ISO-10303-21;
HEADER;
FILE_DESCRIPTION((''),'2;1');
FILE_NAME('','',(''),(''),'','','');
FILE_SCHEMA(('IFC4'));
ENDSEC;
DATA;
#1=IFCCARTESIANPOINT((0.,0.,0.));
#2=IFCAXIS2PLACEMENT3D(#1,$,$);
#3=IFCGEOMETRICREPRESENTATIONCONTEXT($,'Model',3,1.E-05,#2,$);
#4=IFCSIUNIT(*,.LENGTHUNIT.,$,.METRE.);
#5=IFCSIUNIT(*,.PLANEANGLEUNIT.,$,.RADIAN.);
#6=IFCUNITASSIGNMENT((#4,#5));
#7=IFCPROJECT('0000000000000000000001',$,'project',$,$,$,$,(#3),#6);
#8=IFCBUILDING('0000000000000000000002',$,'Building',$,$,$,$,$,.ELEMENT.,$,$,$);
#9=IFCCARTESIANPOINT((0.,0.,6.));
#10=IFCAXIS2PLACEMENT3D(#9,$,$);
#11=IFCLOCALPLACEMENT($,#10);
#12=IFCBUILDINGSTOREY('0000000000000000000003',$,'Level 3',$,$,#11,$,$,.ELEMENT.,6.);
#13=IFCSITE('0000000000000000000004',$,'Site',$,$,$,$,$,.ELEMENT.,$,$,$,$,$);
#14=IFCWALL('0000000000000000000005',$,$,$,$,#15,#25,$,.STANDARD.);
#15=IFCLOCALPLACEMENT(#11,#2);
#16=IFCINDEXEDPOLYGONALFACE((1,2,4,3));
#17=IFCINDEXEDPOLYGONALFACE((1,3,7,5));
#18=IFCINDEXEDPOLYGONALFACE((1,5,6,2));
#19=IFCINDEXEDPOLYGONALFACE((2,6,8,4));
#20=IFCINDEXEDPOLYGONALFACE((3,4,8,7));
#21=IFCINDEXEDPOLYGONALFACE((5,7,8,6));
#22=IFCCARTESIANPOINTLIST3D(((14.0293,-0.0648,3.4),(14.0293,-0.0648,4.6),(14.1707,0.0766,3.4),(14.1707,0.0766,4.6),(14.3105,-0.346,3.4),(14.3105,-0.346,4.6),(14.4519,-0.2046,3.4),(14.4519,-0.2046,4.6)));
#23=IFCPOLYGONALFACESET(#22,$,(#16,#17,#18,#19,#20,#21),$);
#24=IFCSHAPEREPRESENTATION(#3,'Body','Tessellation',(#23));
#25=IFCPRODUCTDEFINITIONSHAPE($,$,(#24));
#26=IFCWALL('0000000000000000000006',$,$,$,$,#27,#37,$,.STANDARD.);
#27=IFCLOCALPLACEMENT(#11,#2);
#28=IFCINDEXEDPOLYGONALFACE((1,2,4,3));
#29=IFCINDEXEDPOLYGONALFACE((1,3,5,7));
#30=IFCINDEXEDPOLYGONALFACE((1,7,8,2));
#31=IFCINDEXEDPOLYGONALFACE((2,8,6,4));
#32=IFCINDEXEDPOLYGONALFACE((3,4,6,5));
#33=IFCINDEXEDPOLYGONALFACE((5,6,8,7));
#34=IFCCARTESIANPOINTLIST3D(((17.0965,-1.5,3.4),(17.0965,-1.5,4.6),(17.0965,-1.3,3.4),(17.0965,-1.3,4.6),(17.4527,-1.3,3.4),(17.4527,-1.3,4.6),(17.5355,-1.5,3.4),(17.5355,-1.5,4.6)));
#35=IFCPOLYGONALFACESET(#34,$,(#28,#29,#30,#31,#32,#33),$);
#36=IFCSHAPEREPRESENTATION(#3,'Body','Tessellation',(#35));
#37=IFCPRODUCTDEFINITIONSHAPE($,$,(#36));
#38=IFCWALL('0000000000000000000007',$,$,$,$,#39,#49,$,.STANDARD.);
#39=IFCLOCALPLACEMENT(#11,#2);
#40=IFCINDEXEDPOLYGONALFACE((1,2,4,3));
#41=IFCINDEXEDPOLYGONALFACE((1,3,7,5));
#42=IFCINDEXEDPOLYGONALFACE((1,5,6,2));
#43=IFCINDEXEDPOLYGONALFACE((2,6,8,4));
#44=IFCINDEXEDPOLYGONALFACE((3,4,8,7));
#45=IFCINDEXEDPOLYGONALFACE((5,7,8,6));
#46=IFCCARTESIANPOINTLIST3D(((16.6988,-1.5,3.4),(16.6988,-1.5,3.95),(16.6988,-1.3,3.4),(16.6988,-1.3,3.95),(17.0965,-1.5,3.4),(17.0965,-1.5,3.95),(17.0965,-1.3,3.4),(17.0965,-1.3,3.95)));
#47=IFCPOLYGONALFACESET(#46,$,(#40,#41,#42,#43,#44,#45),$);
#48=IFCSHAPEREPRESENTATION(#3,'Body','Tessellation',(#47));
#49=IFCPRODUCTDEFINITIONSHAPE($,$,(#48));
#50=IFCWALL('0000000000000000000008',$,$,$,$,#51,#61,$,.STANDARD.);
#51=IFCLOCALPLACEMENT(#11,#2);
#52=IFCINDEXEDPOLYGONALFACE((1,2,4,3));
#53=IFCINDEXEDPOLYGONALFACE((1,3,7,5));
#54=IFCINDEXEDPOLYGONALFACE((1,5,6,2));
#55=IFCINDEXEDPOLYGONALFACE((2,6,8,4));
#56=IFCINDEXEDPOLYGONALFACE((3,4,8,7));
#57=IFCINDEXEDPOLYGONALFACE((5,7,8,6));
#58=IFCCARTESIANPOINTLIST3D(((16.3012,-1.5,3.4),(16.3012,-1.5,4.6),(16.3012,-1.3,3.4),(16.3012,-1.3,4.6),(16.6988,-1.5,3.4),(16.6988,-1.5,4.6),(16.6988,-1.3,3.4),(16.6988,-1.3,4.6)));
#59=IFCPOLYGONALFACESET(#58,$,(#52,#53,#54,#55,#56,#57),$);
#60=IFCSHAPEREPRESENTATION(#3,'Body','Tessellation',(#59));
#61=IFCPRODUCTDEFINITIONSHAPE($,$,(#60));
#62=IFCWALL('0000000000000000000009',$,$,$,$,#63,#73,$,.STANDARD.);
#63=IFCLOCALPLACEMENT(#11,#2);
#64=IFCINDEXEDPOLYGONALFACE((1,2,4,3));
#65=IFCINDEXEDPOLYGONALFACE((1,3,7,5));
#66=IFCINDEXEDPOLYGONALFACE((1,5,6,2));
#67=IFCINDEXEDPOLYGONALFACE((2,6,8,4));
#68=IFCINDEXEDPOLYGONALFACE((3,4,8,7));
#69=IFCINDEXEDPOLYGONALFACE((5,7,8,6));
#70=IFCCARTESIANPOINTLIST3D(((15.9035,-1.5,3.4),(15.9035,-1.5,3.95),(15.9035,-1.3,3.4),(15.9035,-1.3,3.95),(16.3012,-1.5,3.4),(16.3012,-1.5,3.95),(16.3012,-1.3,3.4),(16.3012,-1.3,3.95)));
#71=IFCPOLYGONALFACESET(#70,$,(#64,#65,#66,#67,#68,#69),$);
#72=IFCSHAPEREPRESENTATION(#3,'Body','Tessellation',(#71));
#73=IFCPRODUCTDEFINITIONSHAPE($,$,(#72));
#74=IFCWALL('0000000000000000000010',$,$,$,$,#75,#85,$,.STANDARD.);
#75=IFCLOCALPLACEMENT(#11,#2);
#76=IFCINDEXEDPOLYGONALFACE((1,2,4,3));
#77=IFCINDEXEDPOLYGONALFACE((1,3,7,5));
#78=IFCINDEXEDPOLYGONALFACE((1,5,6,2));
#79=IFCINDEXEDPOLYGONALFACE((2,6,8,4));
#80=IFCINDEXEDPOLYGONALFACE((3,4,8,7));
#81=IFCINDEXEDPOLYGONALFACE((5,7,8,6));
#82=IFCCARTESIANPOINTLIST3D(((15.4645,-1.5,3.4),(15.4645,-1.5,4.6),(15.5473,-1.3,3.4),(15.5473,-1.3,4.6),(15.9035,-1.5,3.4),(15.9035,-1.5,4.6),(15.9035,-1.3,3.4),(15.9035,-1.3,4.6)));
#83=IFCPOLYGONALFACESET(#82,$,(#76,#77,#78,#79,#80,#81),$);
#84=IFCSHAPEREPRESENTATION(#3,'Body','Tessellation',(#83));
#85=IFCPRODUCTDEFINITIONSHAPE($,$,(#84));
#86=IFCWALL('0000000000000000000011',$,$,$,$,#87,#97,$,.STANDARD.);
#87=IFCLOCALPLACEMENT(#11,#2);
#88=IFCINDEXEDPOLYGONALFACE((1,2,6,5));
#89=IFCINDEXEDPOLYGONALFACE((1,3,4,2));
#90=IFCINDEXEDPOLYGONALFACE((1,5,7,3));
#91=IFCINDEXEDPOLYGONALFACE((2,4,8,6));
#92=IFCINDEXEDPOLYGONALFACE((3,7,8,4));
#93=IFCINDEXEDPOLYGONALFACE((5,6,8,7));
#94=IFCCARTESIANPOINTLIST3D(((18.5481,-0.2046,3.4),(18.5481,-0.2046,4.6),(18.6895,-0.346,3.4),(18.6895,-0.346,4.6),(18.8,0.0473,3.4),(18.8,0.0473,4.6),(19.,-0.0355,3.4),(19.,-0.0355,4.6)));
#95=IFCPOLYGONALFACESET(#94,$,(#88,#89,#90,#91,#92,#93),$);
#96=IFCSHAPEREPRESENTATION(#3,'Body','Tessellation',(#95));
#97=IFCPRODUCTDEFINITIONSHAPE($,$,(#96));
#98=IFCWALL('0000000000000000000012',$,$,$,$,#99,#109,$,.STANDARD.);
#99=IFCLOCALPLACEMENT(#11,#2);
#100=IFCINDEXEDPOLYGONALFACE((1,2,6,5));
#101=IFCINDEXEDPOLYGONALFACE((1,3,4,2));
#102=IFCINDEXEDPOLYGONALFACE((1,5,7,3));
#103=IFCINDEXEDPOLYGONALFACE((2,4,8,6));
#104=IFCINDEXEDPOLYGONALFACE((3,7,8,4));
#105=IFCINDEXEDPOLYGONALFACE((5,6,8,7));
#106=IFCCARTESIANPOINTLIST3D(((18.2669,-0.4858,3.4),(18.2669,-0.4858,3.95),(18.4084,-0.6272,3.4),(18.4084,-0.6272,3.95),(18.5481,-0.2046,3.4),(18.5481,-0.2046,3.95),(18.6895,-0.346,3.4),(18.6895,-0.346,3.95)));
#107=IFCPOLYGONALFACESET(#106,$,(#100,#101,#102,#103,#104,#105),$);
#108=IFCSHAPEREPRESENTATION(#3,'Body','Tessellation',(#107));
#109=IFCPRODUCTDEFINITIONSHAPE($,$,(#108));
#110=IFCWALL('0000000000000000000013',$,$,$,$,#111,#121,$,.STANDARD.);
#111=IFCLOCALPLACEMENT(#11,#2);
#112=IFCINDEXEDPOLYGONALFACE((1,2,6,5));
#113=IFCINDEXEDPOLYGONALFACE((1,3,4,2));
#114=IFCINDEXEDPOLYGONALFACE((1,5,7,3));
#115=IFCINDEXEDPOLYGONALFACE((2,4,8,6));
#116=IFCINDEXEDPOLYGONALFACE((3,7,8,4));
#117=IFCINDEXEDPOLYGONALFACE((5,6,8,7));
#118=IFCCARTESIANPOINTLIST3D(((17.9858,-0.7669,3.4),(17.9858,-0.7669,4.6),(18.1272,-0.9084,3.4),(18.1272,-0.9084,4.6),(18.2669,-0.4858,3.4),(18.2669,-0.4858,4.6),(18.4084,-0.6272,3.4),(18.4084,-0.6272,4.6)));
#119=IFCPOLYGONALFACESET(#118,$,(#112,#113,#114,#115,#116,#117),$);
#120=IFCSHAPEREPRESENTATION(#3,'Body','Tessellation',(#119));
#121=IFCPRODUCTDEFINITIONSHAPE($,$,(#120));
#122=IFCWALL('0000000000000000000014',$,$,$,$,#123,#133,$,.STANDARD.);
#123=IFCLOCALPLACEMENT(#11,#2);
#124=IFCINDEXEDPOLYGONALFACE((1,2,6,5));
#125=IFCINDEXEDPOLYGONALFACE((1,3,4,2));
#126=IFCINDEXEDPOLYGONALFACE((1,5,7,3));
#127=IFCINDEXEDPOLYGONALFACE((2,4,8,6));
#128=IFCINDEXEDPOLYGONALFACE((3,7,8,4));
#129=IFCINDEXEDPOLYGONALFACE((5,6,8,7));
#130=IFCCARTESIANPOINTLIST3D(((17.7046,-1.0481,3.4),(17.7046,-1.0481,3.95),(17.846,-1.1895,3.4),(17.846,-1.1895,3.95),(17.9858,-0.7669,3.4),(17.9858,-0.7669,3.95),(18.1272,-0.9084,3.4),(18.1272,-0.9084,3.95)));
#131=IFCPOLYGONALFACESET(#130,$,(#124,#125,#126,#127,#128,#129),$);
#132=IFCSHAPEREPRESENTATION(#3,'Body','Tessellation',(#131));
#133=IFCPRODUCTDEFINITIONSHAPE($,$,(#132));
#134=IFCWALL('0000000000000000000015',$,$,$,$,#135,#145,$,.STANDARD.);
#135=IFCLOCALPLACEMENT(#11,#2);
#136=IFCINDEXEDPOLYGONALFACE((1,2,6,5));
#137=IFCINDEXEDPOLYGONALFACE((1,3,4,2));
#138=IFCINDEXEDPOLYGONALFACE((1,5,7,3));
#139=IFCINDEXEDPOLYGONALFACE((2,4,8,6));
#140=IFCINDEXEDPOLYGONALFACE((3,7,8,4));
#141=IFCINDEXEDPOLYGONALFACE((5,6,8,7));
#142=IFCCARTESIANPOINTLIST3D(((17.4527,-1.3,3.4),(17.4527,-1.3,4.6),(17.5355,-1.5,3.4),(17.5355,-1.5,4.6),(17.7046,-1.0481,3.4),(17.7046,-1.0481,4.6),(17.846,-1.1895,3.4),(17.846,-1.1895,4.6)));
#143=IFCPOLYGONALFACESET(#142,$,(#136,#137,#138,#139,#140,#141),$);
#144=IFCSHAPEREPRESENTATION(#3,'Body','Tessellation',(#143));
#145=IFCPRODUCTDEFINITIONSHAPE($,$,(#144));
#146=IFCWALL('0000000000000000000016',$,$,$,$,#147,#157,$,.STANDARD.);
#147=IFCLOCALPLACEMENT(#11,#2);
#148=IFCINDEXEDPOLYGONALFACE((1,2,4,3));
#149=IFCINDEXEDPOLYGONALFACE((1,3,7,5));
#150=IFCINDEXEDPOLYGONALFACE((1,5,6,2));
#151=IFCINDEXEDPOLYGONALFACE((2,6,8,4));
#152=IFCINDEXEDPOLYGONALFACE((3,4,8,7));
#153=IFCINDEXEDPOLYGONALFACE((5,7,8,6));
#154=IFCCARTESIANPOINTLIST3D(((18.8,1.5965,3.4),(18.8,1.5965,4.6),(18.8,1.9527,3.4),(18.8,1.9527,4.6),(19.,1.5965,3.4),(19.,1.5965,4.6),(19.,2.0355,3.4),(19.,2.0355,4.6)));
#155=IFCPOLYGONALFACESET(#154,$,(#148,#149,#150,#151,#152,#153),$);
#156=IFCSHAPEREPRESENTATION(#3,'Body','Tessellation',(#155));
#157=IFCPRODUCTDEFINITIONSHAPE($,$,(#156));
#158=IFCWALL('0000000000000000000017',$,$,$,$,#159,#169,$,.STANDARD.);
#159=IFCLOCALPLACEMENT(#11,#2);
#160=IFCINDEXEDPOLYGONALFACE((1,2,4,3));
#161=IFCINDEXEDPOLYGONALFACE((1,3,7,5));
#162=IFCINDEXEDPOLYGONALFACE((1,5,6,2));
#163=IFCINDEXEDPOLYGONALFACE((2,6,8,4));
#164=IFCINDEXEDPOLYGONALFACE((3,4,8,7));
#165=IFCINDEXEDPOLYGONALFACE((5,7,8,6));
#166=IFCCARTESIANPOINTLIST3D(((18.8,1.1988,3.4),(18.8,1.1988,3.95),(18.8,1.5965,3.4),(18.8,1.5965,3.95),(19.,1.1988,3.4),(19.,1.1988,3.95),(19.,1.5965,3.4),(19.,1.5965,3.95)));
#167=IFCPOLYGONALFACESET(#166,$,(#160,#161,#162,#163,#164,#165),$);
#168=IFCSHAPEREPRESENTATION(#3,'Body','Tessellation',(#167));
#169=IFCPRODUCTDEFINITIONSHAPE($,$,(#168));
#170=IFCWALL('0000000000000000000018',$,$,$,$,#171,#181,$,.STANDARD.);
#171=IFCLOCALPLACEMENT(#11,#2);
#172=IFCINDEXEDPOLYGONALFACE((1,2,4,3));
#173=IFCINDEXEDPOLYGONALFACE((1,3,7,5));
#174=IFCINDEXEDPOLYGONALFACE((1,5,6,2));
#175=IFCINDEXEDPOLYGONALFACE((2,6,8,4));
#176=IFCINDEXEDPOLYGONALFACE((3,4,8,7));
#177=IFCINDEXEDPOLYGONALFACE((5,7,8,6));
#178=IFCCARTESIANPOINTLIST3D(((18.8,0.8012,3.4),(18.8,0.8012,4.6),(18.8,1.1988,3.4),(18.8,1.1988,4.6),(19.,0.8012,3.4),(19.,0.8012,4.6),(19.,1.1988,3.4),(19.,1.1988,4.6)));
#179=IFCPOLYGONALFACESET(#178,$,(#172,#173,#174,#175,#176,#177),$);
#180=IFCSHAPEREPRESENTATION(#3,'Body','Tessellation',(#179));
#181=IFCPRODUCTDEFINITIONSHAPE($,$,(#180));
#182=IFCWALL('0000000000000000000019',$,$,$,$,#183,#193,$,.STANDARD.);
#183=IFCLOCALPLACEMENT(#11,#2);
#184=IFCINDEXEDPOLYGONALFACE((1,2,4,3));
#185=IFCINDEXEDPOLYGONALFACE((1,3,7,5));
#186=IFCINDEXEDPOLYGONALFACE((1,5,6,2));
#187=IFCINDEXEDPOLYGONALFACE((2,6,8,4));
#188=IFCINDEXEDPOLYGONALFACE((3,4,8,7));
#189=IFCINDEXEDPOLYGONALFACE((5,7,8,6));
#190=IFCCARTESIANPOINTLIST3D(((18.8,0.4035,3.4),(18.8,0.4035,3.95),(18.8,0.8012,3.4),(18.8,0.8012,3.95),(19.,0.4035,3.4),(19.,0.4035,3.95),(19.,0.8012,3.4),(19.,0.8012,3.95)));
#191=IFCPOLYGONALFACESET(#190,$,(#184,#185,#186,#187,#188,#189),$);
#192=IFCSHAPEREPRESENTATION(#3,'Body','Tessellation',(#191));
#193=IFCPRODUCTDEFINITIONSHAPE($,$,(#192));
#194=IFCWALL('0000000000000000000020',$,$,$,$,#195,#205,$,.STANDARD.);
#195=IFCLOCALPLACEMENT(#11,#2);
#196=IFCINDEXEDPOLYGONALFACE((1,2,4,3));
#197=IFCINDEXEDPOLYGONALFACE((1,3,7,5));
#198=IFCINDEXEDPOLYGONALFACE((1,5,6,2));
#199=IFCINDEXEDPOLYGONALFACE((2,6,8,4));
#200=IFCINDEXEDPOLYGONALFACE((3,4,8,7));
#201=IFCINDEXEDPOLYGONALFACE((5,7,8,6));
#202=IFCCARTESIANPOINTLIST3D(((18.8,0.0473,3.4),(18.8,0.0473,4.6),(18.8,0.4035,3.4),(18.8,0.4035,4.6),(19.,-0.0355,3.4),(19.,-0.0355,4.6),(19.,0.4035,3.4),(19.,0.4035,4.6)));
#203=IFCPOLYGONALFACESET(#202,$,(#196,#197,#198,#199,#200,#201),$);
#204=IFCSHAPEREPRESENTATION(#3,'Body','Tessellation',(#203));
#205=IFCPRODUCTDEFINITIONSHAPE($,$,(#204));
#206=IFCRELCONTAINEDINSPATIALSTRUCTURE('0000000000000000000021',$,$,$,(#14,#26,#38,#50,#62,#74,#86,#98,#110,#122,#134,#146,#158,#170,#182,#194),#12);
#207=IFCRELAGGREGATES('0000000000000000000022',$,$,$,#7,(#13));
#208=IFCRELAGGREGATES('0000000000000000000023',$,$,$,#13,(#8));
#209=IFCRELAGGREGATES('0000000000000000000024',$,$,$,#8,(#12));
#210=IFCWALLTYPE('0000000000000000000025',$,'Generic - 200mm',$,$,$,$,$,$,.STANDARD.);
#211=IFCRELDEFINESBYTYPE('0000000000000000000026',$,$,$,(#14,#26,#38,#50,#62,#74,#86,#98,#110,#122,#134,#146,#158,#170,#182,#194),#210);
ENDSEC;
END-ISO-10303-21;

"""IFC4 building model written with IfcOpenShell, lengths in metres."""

from ifc_helpers import new_model, si_unit, frame, frame_2d, origin, place, context, project, spatial, polyline, rectangle, outline, extrude, type_object, element, save


model = new_model("IFC4")

# Units and contexts
model_context = context("Model", 3, precision=1e-05, world=origin())
ifc_project = project(units=[si_unit("LENGTHUNIT", "METRE"), si_unit("PLANEANGLEUNIT", "RADIAN")], contexts=[model_context])

# Site, building, storey
site = spatial("IfcSite", under=ifc_project, Name="Site", CompositionType="ELEMENT")
building = spatial("IfcBuilding", under=site, Name="Building", CompositionType="ELEMENT")
storey_placement = place(None, frame((0.0, 0.0, 6.0)))
storey = spatial("IfcBuildingStorey", under=building, at=storey_placement, Name="Level 3", CompositionType="ELEMENT", Elevation=6.0)

# Walls
wall_type = type_object("IfcWallType", Name="Generic - 200mm", PredefinedType="STANDARD")
wall_1_placement = place(None, frame((14.3812, -0.2753, 9.4), z_axis=(0.0, 0.0, 1.0), x_axis=(-0.707107, 0.707107, 0.0)))
element("IfcWall", 1, at=wall_1_placement, inside=storey, type_object=wall_type, PredefinedType="STANDARD", context=model_context, shape_type="SweptSolid", body=[
    extrude(rectangle(XDim=0.3976, YDim=0.2, at=frame_2d((0.1988, 0.0))), origin(), (0.0, 0.0, 1.0), 1.2),
])
wall_2_placement = place(None, frame((17.4941, -1.4, 9.4), z_axis=(0.0, 0.0, 1.0), x_axis=(-1.0, 0.0, 0.0)))
element("IfcWall", 2, at=wall_2_placement, inside=storey, type_object=wall_type, PredefinedType="STANDARD", context=model_context, shape_type="SweptSolid", body=[
    extrude(outline(polyline([(0.0414, -0.1), (0.3976, -0.1), (0.3976, 0.1), (-0.0414, 0.1), (0.0414, -0.1)])), origin(), (0.0, 0.0, 1.0), 1.2),
])
wall_3_placement = place(None, frame((17.0965, -1.4, 9.4), z_axis=(0.0, 0.0, 1.0), x_axis=(-1.0, 0.0, 0.0)))
element("IfcWall", 3, at=wall_3_placement, inside=storey, type_object=wall_type, PredefinedType="STANDARD", context=model_context, shape_type="SweptSolid", body=[
    extrude(rectangle(XDim=0.3976, YDim=0.2, at=frame_2d((0.1988, 0.0))), origin(), (0.0, 0.0, 1.0), 0.55),
])
wall_4_placement = place(None, frame((16.6988, -1.4, 9.4), z_axis=(0.0, 0.0, 1.0), x_axis=(-1.0, 0.0, 0.0)))
element("IfcWall", 4, at=wall_4_placement, inside=storey, type_object=wall_type, PredefinedType="STANDARD", context=model_context, shape_type="SweptSolid", body=[
    extrude(rectangle(XDim=0.3976, YDim=0.2, at=frame_2d((0.1988, 0.0))), origin(), (0.0, 0.0, 1.0), 1.2),
])
wall_5_placement = place(None, frame((16.3012, -1.4, 9.4), z_axis=(0.0, 0.0, 1.0), x_axis=(-1.0, 0.0, 0.0)))
element("IfcWall", 5, at=wall_5_placement, inside=storey, type_object=wall_type, PredefinedType="STANDARD", context=model_context, shape_type="SweptSolid", body=[
    extrude(rectangle(XDim=0.3976, YDim=0.2, at=frame_2d((0.1988, 0.0))), origin(), (0.0, 0.0, 1.0), 0.55),
])
wall_6_placement = place(None, frame((15.9035, -1.4, 9.4), z_axis=(0.0, 0.0, 1.0), x_axis=(-1.0, 0.0, 0.0)))
element("IfcWall", 6, at=wall_6_placement, inside=storey, type_object=wall_type, PredefinedType="STANDARD", context=model_context, shape_type="SweptSolid", body=[
    extrude(outline(polyline([(0.0, -0.1), (0.3562, -0.1), (0.4391, 0.1), (0.0, 0.1), (0.0, -0.1)])), origin(), (0.0, 0.0, 1.0), 1.2),
])
wall_7_placement = place(None, frame((18.9, 0.0059, 9.4), z_axis=(0.0, 0.0, 1.0), x_axis=(-0.707107, -0.707107, 0.0)))
element("IfcWall", 7, at=wall_7_placement, inside=storey, type_object=wall_type, PredefinedType="STANDARD", context=model_context, shape_type="SweptSolid", body=[
    extrude(outline(polyline([(0.0414, -0.1), (0.3976, -0.1), (0.3976, 0.1), (-0.0414, 0.1), (0.0414, -0.1)])), origin(), (0.0, 0.0, 1.0), 1.2),
])
wall_8_placement = place(None, frame((18.6188, -0.2753, 9.4), z_axis=(0.0, 0.0, 1.0), x_axis=(-0.707107, -0.707107, 0.0)))
element("IfcWall", 8, at=wall_8_placement, inside=storey, type_object=wall_type, PredefinedType="STANDARD", context=model_context, shape_type="SweptSolid", body=[
    extrude(rectangle(XDim=0.3976, YDim=0.2, at=frame_2d((0.1988, 0.0))), origin(), (0.0, 0.0, 1.0), 0.55),
])
wall_9_placement = place(None, frame((18.3376, -0.5565, 9.4), z_axis=(0.0, 0.0, 1.0), x_axis=(-0.707107, -0.707107, 0.0)))
element("IfcWall", 9, at=wall_9_placement, inside=storey, type_object=wall_type, PredefinedType="STANDARD", context=model_context, shape_type="SweptSolid", body=[
    extrude(rectangle(XDim=0.3976, YDim=0.2, at=frame_2d((0.1988, 0.0))), origin(), (0.0, 0.0, 1.0), 1.2),
])
wall_10_placement = place(None, frame((18.0565, -0.8376, 9.4), z_axis=(0.0, 0.0, 1.0), x_axis=(-0.707107, -0.707107, 0.0)))
element("IfcWall", 10, at=wall_10_placement, inside=storey, type_object=wall_type, PredefinedType="STANDARD", context=model_context, shape_type="SweptSolid", body=[
    extrude(rectangle(XDim=0.3976, YDim=0.2, at=frame_2d((0.1988, 0.0))), origin(), (0.0, 0.0, 1.0), 0.55),
])
wall_11_placement = place(None, frame((17.7753, -1.1188, 9.4), z_axis=(0.0, 0.0, 1.0), x_axis=(-0.707107, -0.707107, 0.0)))
element("IfcWall", 11, at=wall_11_placement, inside=storey, type_object=wall_type, PredefinedType="STANDARD", context=model_context, shape_type="SweptSolid", body=[
    extrude(outline(polyline([(0.0, -0.1), (0.3562, -0.1), (0.4391, 0.1), (0.0, 0.1), (0.0, -0.1)])), origin(), (0.0, 0.0, 1.0), 1.2),
])
wall_12_placement = place(None, frame((18.9, 1.9941, 9.4), z_axis=(0.0, 0.0, 1.0), x_axis=(0.0, -1.0, 0.0)))
element("IfcWall", 12, at=wall_12_placement, inside=storey, type_object=wall_type, PredefinedType="STANDARD", context=model_context, shape_type="SweptSolid", body=[
    extrude(outline(polyline([(0.0414, -0.1), (0.3976, -0.1), (0.3976, 0.1), (-0.0414, 0.1), (0.0414, -0.1)])), origin(), (0.0, 0.0, 1.0), 1.2),
])
wall_13_placement = place(None, frame((18.9, 1.5965, 9.4), z_axis=(0.0, 0.0, 1.0), x_axis=(0.0, -1.0, 0.0)))
element("IfcWall", 13, at=wall_13_placement, inside=storey, type_object=wall_type, PredefinedType="STANDARD", context=model_context, shape_type="SweptSolid", body=[
    extrude(rectangle(XDim=0.3976, YDim=0.2, at=frame_2d((0.1988, 0.0))), origin(), (0.0, 0.0, 1.0), 0.55),
])
wall_14_placement = place(None, frame((18.9, 1.1988, 9.4), z_axis=(0.0, 0.0, 1.0), x_axis=(0.0, -1.0, 0.0)))
element("IfcWall", 14, at=wall_14_placement, inside=storey, type_object=wall_type, PredefinedType="STANDARD", context=model_context, shape_type="SweptSolid", body=[
    extrude(rectangle(XDim=0.3976, YDim=0.2, at=frame_2d((0.1988, 0.0))), origin(), (0.0, 0.0, 1.0), 1.2),
])
wall_15_placement = place(None, frame((18.9, 0.8012, 9.4), z_axis=(0.0, 0.0, 1.0), x_axis=(0.0, -1.0, 0.0)))
element("IfcWall", 15, at=wall_15_placement, inside=storey, type_object=wall_type, PredefinedType="STANDARD", context=model_context, shape_type="SweptSolid", body=[
    extrude(rectangle(XDim=0.3976, YDim=0.2, at=frame_2d((0.1988, 0.0))), origin(), (0.0, 0.0, 1.0), 0.55),
])
wall_16_placement = place(None, frame((18.9, 0.4035, 9.4), z_axis=(0.0, 0.0, 1.0), x_axis=(0.0, -1.0, 0.0)))
element("IfcWall", 16, at=wall_16_placement, inside=storey, type_object=wall_type, PredefinedType="STANDARD", context=model_context, shape_type="SweptSolid", body=[
    extrude(outline(polyline([(0.0, -0.1), (0.3562, -0.1), (0.4391, 0.1), (0.0, 0.1), (0.0, -0.1)])), origin(), (0.0, 0.0, 1.0), 1.2),
])

save(model, "model.ifc")
